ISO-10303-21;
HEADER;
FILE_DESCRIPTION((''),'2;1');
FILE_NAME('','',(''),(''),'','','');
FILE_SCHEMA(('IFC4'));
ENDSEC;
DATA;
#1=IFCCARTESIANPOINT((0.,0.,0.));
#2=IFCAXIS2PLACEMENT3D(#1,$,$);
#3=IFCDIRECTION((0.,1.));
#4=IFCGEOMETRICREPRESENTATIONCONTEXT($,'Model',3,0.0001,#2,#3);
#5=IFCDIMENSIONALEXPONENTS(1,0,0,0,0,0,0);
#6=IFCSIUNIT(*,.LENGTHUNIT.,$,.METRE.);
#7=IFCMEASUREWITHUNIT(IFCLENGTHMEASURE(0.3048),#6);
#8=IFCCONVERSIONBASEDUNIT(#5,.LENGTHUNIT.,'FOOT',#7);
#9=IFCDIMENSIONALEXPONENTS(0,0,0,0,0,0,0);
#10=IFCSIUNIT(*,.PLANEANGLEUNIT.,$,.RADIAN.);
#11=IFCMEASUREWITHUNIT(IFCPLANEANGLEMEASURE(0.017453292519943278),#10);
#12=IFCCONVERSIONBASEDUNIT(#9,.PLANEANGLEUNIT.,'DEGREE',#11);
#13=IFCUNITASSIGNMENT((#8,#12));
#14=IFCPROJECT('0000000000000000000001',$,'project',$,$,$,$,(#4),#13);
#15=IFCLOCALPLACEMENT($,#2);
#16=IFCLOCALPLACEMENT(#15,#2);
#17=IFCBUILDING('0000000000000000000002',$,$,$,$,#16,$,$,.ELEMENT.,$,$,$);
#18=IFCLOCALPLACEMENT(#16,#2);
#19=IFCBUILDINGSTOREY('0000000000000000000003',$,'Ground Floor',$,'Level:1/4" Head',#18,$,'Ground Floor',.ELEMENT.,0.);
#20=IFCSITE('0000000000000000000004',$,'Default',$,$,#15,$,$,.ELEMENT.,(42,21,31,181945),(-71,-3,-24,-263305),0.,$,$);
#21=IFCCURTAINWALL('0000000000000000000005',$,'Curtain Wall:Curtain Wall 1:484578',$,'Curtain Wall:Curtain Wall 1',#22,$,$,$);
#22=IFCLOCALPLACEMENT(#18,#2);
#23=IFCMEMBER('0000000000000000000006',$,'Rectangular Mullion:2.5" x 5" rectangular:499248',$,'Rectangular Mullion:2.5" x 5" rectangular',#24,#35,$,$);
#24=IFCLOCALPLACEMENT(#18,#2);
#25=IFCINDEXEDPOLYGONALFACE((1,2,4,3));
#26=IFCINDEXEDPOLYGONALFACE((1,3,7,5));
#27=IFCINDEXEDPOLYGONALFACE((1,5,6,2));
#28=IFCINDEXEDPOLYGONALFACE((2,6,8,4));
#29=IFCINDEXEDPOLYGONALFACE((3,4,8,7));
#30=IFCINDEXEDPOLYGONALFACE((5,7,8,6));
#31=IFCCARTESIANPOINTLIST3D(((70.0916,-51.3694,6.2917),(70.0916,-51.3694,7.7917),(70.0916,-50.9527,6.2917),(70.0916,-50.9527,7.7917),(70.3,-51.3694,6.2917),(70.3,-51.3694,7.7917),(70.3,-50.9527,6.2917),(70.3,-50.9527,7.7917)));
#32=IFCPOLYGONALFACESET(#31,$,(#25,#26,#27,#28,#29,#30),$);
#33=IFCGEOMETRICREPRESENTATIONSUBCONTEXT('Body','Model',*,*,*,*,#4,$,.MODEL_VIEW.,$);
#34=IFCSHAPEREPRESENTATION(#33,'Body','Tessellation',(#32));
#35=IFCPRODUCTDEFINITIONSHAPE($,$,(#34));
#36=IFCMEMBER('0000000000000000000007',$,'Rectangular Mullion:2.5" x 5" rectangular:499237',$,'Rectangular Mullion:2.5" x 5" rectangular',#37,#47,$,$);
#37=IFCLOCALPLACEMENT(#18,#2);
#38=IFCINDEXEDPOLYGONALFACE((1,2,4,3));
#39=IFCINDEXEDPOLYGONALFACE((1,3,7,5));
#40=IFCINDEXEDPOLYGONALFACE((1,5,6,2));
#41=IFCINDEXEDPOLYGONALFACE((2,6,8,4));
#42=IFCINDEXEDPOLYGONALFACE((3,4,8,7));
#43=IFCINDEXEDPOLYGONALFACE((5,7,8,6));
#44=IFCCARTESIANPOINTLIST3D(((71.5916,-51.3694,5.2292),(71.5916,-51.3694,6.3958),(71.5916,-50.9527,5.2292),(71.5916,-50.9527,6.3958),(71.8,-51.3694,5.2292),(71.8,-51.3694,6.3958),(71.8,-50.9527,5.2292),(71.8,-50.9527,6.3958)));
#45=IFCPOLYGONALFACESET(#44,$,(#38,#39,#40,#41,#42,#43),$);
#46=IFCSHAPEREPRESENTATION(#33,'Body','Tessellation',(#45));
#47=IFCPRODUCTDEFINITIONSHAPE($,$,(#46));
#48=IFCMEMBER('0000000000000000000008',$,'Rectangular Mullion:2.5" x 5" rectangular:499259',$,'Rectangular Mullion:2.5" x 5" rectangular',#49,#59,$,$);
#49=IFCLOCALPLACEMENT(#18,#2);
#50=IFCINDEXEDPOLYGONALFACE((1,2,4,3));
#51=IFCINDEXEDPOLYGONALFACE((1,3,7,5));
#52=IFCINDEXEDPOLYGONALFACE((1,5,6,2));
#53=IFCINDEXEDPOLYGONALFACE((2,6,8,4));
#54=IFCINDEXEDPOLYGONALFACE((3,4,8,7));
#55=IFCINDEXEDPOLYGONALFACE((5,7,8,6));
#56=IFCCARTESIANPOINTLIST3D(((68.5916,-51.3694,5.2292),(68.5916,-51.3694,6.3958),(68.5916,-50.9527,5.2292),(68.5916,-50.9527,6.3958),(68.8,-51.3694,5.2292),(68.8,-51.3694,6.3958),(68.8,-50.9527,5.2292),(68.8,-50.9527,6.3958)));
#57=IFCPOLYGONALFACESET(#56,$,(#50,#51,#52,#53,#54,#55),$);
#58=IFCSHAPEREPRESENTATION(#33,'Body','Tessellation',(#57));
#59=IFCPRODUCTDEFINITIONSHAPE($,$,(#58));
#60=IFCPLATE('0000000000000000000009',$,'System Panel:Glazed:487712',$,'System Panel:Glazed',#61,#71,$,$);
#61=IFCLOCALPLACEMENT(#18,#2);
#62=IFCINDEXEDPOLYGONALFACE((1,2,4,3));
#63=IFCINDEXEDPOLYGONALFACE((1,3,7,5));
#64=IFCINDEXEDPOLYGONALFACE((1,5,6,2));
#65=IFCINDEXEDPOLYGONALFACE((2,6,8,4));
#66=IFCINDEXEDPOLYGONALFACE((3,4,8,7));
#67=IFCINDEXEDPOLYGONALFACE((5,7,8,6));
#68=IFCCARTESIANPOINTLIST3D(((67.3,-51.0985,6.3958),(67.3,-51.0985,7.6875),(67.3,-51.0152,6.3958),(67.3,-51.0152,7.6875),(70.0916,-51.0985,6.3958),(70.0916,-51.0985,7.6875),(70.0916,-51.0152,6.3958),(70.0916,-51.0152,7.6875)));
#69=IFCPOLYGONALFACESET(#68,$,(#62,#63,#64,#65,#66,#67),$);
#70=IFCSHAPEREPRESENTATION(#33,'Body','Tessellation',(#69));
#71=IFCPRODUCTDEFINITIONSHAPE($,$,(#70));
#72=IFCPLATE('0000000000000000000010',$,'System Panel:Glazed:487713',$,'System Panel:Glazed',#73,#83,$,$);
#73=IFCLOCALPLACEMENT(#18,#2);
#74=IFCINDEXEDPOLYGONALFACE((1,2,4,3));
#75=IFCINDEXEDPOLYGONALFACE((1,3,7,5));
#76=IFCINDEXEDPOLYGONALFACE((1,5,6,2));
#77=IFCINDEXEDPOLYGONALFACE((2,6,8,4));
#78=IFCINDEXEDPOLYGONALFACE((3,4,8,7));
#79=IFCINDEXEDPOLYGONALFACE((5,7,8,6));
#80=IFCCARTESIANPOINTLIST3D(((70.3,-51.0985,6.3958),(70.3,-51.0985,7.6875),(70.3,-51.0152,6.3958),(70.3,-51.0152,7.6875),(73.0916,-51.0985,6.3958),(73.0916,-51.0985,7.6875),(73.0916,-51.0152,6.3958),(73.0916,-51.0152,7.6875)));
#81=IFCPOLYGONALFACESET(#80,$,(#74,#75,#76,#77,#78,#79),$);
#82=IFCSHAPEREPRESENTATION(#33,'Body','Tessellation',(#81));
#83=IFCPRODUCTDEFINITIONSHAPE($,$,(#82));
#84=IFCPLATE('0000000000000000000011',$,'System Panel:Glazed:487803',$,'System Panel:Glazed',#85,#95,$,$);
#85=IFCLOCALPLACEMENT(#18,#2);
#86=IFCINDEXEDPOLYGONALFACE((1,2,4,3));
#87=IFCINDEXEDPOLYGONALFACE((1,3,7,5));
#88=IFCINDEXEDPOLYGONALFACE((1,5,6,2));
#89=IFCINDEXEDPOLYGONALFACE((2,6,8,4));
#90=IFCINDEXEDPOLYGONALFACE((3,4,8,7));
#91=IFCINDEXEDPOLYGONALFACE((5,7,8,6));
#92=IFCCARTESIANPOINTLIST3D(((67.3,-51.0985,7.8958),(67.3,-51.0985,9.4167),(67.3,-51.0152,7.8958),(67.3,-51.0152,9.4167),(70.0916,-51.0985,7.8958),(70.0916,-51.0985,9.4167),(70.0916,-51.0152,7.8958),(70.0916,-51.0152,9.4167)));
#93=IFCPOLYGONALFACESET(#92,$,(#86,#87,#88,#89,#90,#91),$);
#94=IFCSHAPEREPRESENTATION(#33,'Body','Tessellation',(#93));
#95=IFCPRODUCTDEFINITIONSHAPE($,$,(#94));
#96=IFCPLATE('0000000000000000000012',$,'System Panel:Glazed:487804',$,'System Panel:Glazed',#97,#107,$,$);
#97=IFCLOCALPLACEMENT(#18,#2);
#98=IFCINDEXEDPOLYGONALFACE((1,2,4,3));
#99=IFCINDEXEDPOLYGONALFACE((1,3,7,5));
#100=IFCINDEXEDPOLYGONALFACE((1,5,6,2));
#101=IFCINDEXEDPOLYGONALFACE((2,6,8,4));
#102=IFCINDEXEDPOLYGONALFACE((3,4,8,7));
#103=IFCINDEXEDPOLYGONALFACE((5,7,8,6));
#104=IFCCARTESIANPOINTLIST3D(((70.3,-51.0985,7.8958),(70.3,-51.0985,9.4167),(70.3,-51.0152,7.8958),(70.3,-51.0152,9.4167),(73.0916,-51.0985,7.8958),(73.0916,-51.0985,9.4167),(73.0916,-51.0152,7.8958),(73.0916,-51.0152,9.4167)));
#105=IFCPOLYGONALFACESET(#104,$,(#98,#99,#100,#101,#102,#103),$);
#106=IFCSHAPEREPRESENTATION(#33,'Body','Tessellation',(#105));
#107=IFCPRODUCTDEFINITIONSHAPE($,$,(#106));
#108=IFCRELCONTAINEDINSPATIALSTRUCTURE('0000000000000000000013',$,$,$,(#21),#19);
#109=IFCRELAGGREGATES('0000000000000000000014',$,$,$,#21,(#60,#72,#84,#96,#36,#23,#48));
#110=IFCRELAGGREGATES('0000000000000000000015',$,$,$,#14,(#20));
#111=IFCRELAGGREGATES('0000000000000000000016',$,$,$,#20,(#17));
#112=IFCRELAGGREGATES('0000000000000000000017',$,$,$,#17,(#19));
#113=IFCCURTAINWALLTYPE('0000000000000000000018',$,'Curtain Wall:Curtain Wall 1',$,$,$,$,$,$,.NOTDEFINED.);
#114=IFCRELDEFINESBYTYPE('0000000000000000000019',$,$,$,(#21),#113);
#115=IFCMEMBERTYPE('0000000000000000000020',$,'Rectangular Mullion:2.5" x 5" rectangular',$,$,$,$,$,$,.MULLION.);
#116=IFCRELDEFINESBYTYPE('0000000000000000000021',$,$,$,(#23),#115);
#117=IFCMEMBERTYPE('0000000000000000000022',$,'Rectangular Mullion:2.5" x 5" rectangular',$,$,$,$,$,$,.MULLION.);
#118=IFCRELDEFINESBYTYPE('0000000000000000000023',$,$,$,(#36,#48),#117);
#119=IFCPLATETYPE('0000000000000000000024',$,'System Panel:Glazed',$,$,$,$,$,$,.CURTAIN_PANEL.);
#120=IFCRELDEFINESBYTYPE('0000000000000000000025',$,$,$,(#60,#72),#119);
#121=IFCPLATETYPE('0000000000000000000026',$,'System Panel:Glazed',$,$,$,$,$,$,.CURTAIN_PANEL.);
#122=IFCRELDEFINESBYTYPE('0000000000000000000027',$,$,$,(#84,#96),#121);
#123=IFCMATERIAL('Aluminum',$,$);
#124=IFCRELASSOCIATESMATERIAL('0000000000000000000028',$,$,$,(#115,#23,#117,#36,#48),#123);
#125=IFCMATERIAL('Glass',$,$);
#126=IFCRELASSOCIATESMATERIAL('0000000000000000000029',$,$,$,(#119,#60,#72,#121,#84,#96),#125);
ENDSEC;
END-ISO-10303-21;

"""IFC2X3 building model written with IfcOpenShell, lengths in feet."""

from ifc_helpers import new_model, entity, si_unit, converted_unit, direction, frame, origin, origin_2d_with_axis, place, context, subcontext, project, spatial, rectangle, extrude, source, transform, mapped, material, type_object, type_shapes, element, aggregate, save


model = new_model("IFC2X3")

# Units and contexts
model_context = context("Model", 3, precision=0.0001, world=origin(), true_north=direction((0.0, 1.0)))
body_context = subcontext(model_context, "Body", "Model", "MODEL_VIEW")
ifc_project = project(units=[converted_unit("LENGTHUNIT", "FOOT", entity("IfcLengthMeasure", 0.3048), si_unit("LENGTHUNIT", "METRE"), dimensions=[1, 0, 0, 0, 0, 0, 0]), converted_unit("PLANEANGLEUNIT", "DEGREE", entity("IfcPlaneAngleMeasure", 0.017453292519943278), si_unit("PLANEANGLEUNIT", "RADIAN"), dimensions=[0, 0, 0, 0, 0, 0, 0])], contexts=[model_context])

# Site, building, storey
site_placement = place(None, origin())
site = spatial("IfcSite", under=ifc_project, at=site_placement, Name="Default", CompositionType="ELEMENT", RefLatitude=(42, 21, 31, 181945), RefLongitude=(-71, -3, -24, -263305), RefElevation=0.0)
building_placement = place(site_placement, origin())
building = spatial("IfcBuilding", under=site, at=building_placement, CompositionType="ELEMENT")
storey_placement = place(building_placement, origin())
storey = spatial("IfcBuildingStorey", under=building, at=storey_placement, Name="Ground Floor", ObjectType="Level:1/4\" Head", LongName="Ground Floor", CompositionType="ELEMENT", Elevation=0.0)

# Curtain wall, members, plates
curtain_wall_type = type_object("IfcCurtainWallType", Name="Curtain Wall:Curtain Wall 1", PredefinedType="NOTDEFINED")
curtain_wall_placement = place(storey_placement, origin())
curtain_wall = element("IfcCurtainWall", 1, at=curtain_wall_placement, inside=storey, type_object=curtain_wall_type, Name="Curtain Wall:Curtain Wall 1:484578", ObjectType="Curtain Wall:Curtain Wall 1")
ifc_material_1 = material(Name="Aluminum")
member_type_1 = type_object("IfcMemberType", Name="Rectangular Mullion:2.5\" x 5\" rectangular", PredefinedType="MULLION", material=ifc_material_1)
shared_shape_1 = source(origin(), body_context, "Body", "SweptSolid", [
    extrude(rectangle(XDim=0.2083, YDim=0.4167, at=origin_2d_with_axis()), frame((0.0, 0.0, -1.5), z_axis=(0.0, 0.0, 1.0), x_axis=(-1.0, 0.0, 0.0)), (0.0, 0.0, 1.0), 1.5),
])
type_shapes(member_type_1, [shared_shape_1])
member_1_placement = place(curtain_wall_placement, frame((70.1958, -51.161, 6.2917), z_axis=(0.0, 0.0, -1.0), x_axis=(1.0, 0.0, 0.0)))
member_1 = element("IfcMember", 2, at=member_1_placement, type_object=member_type_1, material=ifc_material_1, Name="Rectangular Mullion:2.5\" x 5\" rectangular:499248", ObjectType="Rectangular Mullion:2.5\" x 5\" rectangular", context=body_context, shape_type="MappedRepresentation", body=[
    mapped(shared_shape_1, transform((0.0, 0.0, 0.0), scale=1.0)),
])
member_type_2 = type_object("IfcMemberType", Name="Rectangular Mullion:2.5\" x 5\" rectangular", PredefinedType="MULLION", material=ifc_material_1)
shared_shape_2 = source(origin(), body_context, "Body", "SweptSolid", [
    extrude(rectangle(XDim=0.2083, YDim=0.4167, at=origin_2d_with_axis()), frame((0.0, 0.0, -1.1667), z_axis=(0.0, 0.0, 1.0), x_axis=(-1.0, 0.0, 0.0)), (0.0, 0.0, 1.0), 1.1667),
])
type_shapes(member_type_2, [shared_shape_2])
member_2_placement = place(curtain_wall_placement, frame((71.6958, -51.161, 5.2292), z_axis=(0.0, 0.0, -1.0), x_axis=(1.0, 0.0, 0.0)))
member_2 = element("IfcMember", 3, at=member_2_placement, type_object=member_type_2, material=ifc_material_1, Name="Rectangular Mullion:2.5\" x 5\" rectangular:499237", ObjectType="Rectangular Mullion:2.5\" x 5\" rectangular", context=body_context, shape_type="MappedRepresentation", body=[
    mapped(shared_shape_2, transform((0.0, 0.0, 0.0), scale=1.0)),
])
member_3_placement = place(curtain_wall_placement, frame((68.6958, -51.161, 5.2292), z_axis=(0.0, 0.0, -1.0), x_axis=(1.0, 0.0, 0.0)))
member_3 = element("IfcMember", 4, at=member_3_placement, type_object=member_type_2, material=ifc_material_1, Name="Rectangular Mullion:2.5\" x 5\" rectangular:499259", ObjectType="Rectangular Mullion:2.5\" x 5\" rectangular", context=body_context, shape_type="MappedRepresentation", body=[
    mapped(shared_shape_2, transform((0.0, 0.0, 0.0), scale=1.0)),
])
ifc_material_2 = material(Name="Glass")
plate_type_1 = type_object("IfcPlateType", Name="System Panel:Glazed", PredefinedType="CURTAIN_PANEL", material=ifc_material_2)
shared_shape_3 = source(origin(), body_context, "Body", "SweptSolid", [
    extrude(rectangle(XDim=1.2917, YDim=2.7917, at=origin_2d_with_axis()), frame((0.0, 0.0625, 0.6458), z_axis=(0.0, 1.0, 0.0), x_axis=(0.0, 0.0, 1.0)), (0.0, 0.0, 1.0), 0.0833),
])
type_shapes(plate_type_1, [shared_shape_3])
plate_1_placement = place(curtain_wall_placement, frame((68.6958, -51.161, 6.3958)))
plate_1 = element("IfcPlate", 5, at=plate_1_placement, type_object=plate_type_1, material=ifc_material_2, Name="System Panel:Glazed:487712", ObjectType="System Panel:Glazed", context=body_context, shape_type="MappedRepresentation", body=[
    mapped(shared_shape_3, transform((0.0, 0.0, 0.0), scale=1.0)),
])
plate_2_placement = place(curtain_wall_placement, frame((71.6958, -51.161, 6.3958)))
plate_2 = element("IfcPlate", 6, at=plate_2_placement, type_object=plate_type_1, material=ifc_material_2, Name="System Panel:Glazed:487713", ObjectType="System Panel:Glazed", context=body_context, shape_type="MappedRepresentation", body=[
    mapped(shared_shape_3, transform((0.0, 0.0, 0.0), scale=1.0)),
])
plate_type_2 = type_object("IfcPlateType", Name="System Panel:Glazed", PredefinedType="CURTAIN_PANEL", material=ifc_material_2)
shared_shape_4 = source(origin(), body_context, "Body", "SweptSolid", [
    extrude(rectangle(XDim=1.5208, YDim=2.7917, at=origin_2d_with_axis()), frame((0.0, 0.0625, 0.7604), z_axis=(0.0, 1.0, 0.0), x_axis=(0.0, 0.0, 1.0)), (0.0, 0.0, 1.0), 0.0833),
])
type_shapes(plate_type_2, [shared_shape_4])
plate_3_placement = place(curtain_wall_placement, frame((68.6958, -51.161, 7.8958)))
plate_3 = element("IfcPlate", 7, at=plate_3_placement, type_object=plate_type_2, material=ifc_material_2, Name="System Panel:Glazed:487803", ObjectType="System Panel:Glazed", context=body_context, shape_type="MappedRepresentation", body=[
    mapped(shared_shape_4, transform((0.0, 0.0, 0.0), scale=1.0)),
])
plate_4_placement = place(curtain_wall_placement, frame((71.6958, -51.161, 7.8958)))
plate_4 = element("IfcPlate", 8, at=plate_4_placement, type_object=plate_type_2, material=ifc_material_2, Name="System Panel:Glazed:487804", ObjectType="System Panel:Glazed", context=body_context, shape_type="MappedRepresentation", body=[
    mapped(shared_shape_4, transform((0.0, 0.0, 0.0), scale=1.0)),
])
aggregate(curtain_wall, [plate_1, plate_2, plate_3, plate_4, member_2, member_1, member_3])

save(model, "model.ifc")
